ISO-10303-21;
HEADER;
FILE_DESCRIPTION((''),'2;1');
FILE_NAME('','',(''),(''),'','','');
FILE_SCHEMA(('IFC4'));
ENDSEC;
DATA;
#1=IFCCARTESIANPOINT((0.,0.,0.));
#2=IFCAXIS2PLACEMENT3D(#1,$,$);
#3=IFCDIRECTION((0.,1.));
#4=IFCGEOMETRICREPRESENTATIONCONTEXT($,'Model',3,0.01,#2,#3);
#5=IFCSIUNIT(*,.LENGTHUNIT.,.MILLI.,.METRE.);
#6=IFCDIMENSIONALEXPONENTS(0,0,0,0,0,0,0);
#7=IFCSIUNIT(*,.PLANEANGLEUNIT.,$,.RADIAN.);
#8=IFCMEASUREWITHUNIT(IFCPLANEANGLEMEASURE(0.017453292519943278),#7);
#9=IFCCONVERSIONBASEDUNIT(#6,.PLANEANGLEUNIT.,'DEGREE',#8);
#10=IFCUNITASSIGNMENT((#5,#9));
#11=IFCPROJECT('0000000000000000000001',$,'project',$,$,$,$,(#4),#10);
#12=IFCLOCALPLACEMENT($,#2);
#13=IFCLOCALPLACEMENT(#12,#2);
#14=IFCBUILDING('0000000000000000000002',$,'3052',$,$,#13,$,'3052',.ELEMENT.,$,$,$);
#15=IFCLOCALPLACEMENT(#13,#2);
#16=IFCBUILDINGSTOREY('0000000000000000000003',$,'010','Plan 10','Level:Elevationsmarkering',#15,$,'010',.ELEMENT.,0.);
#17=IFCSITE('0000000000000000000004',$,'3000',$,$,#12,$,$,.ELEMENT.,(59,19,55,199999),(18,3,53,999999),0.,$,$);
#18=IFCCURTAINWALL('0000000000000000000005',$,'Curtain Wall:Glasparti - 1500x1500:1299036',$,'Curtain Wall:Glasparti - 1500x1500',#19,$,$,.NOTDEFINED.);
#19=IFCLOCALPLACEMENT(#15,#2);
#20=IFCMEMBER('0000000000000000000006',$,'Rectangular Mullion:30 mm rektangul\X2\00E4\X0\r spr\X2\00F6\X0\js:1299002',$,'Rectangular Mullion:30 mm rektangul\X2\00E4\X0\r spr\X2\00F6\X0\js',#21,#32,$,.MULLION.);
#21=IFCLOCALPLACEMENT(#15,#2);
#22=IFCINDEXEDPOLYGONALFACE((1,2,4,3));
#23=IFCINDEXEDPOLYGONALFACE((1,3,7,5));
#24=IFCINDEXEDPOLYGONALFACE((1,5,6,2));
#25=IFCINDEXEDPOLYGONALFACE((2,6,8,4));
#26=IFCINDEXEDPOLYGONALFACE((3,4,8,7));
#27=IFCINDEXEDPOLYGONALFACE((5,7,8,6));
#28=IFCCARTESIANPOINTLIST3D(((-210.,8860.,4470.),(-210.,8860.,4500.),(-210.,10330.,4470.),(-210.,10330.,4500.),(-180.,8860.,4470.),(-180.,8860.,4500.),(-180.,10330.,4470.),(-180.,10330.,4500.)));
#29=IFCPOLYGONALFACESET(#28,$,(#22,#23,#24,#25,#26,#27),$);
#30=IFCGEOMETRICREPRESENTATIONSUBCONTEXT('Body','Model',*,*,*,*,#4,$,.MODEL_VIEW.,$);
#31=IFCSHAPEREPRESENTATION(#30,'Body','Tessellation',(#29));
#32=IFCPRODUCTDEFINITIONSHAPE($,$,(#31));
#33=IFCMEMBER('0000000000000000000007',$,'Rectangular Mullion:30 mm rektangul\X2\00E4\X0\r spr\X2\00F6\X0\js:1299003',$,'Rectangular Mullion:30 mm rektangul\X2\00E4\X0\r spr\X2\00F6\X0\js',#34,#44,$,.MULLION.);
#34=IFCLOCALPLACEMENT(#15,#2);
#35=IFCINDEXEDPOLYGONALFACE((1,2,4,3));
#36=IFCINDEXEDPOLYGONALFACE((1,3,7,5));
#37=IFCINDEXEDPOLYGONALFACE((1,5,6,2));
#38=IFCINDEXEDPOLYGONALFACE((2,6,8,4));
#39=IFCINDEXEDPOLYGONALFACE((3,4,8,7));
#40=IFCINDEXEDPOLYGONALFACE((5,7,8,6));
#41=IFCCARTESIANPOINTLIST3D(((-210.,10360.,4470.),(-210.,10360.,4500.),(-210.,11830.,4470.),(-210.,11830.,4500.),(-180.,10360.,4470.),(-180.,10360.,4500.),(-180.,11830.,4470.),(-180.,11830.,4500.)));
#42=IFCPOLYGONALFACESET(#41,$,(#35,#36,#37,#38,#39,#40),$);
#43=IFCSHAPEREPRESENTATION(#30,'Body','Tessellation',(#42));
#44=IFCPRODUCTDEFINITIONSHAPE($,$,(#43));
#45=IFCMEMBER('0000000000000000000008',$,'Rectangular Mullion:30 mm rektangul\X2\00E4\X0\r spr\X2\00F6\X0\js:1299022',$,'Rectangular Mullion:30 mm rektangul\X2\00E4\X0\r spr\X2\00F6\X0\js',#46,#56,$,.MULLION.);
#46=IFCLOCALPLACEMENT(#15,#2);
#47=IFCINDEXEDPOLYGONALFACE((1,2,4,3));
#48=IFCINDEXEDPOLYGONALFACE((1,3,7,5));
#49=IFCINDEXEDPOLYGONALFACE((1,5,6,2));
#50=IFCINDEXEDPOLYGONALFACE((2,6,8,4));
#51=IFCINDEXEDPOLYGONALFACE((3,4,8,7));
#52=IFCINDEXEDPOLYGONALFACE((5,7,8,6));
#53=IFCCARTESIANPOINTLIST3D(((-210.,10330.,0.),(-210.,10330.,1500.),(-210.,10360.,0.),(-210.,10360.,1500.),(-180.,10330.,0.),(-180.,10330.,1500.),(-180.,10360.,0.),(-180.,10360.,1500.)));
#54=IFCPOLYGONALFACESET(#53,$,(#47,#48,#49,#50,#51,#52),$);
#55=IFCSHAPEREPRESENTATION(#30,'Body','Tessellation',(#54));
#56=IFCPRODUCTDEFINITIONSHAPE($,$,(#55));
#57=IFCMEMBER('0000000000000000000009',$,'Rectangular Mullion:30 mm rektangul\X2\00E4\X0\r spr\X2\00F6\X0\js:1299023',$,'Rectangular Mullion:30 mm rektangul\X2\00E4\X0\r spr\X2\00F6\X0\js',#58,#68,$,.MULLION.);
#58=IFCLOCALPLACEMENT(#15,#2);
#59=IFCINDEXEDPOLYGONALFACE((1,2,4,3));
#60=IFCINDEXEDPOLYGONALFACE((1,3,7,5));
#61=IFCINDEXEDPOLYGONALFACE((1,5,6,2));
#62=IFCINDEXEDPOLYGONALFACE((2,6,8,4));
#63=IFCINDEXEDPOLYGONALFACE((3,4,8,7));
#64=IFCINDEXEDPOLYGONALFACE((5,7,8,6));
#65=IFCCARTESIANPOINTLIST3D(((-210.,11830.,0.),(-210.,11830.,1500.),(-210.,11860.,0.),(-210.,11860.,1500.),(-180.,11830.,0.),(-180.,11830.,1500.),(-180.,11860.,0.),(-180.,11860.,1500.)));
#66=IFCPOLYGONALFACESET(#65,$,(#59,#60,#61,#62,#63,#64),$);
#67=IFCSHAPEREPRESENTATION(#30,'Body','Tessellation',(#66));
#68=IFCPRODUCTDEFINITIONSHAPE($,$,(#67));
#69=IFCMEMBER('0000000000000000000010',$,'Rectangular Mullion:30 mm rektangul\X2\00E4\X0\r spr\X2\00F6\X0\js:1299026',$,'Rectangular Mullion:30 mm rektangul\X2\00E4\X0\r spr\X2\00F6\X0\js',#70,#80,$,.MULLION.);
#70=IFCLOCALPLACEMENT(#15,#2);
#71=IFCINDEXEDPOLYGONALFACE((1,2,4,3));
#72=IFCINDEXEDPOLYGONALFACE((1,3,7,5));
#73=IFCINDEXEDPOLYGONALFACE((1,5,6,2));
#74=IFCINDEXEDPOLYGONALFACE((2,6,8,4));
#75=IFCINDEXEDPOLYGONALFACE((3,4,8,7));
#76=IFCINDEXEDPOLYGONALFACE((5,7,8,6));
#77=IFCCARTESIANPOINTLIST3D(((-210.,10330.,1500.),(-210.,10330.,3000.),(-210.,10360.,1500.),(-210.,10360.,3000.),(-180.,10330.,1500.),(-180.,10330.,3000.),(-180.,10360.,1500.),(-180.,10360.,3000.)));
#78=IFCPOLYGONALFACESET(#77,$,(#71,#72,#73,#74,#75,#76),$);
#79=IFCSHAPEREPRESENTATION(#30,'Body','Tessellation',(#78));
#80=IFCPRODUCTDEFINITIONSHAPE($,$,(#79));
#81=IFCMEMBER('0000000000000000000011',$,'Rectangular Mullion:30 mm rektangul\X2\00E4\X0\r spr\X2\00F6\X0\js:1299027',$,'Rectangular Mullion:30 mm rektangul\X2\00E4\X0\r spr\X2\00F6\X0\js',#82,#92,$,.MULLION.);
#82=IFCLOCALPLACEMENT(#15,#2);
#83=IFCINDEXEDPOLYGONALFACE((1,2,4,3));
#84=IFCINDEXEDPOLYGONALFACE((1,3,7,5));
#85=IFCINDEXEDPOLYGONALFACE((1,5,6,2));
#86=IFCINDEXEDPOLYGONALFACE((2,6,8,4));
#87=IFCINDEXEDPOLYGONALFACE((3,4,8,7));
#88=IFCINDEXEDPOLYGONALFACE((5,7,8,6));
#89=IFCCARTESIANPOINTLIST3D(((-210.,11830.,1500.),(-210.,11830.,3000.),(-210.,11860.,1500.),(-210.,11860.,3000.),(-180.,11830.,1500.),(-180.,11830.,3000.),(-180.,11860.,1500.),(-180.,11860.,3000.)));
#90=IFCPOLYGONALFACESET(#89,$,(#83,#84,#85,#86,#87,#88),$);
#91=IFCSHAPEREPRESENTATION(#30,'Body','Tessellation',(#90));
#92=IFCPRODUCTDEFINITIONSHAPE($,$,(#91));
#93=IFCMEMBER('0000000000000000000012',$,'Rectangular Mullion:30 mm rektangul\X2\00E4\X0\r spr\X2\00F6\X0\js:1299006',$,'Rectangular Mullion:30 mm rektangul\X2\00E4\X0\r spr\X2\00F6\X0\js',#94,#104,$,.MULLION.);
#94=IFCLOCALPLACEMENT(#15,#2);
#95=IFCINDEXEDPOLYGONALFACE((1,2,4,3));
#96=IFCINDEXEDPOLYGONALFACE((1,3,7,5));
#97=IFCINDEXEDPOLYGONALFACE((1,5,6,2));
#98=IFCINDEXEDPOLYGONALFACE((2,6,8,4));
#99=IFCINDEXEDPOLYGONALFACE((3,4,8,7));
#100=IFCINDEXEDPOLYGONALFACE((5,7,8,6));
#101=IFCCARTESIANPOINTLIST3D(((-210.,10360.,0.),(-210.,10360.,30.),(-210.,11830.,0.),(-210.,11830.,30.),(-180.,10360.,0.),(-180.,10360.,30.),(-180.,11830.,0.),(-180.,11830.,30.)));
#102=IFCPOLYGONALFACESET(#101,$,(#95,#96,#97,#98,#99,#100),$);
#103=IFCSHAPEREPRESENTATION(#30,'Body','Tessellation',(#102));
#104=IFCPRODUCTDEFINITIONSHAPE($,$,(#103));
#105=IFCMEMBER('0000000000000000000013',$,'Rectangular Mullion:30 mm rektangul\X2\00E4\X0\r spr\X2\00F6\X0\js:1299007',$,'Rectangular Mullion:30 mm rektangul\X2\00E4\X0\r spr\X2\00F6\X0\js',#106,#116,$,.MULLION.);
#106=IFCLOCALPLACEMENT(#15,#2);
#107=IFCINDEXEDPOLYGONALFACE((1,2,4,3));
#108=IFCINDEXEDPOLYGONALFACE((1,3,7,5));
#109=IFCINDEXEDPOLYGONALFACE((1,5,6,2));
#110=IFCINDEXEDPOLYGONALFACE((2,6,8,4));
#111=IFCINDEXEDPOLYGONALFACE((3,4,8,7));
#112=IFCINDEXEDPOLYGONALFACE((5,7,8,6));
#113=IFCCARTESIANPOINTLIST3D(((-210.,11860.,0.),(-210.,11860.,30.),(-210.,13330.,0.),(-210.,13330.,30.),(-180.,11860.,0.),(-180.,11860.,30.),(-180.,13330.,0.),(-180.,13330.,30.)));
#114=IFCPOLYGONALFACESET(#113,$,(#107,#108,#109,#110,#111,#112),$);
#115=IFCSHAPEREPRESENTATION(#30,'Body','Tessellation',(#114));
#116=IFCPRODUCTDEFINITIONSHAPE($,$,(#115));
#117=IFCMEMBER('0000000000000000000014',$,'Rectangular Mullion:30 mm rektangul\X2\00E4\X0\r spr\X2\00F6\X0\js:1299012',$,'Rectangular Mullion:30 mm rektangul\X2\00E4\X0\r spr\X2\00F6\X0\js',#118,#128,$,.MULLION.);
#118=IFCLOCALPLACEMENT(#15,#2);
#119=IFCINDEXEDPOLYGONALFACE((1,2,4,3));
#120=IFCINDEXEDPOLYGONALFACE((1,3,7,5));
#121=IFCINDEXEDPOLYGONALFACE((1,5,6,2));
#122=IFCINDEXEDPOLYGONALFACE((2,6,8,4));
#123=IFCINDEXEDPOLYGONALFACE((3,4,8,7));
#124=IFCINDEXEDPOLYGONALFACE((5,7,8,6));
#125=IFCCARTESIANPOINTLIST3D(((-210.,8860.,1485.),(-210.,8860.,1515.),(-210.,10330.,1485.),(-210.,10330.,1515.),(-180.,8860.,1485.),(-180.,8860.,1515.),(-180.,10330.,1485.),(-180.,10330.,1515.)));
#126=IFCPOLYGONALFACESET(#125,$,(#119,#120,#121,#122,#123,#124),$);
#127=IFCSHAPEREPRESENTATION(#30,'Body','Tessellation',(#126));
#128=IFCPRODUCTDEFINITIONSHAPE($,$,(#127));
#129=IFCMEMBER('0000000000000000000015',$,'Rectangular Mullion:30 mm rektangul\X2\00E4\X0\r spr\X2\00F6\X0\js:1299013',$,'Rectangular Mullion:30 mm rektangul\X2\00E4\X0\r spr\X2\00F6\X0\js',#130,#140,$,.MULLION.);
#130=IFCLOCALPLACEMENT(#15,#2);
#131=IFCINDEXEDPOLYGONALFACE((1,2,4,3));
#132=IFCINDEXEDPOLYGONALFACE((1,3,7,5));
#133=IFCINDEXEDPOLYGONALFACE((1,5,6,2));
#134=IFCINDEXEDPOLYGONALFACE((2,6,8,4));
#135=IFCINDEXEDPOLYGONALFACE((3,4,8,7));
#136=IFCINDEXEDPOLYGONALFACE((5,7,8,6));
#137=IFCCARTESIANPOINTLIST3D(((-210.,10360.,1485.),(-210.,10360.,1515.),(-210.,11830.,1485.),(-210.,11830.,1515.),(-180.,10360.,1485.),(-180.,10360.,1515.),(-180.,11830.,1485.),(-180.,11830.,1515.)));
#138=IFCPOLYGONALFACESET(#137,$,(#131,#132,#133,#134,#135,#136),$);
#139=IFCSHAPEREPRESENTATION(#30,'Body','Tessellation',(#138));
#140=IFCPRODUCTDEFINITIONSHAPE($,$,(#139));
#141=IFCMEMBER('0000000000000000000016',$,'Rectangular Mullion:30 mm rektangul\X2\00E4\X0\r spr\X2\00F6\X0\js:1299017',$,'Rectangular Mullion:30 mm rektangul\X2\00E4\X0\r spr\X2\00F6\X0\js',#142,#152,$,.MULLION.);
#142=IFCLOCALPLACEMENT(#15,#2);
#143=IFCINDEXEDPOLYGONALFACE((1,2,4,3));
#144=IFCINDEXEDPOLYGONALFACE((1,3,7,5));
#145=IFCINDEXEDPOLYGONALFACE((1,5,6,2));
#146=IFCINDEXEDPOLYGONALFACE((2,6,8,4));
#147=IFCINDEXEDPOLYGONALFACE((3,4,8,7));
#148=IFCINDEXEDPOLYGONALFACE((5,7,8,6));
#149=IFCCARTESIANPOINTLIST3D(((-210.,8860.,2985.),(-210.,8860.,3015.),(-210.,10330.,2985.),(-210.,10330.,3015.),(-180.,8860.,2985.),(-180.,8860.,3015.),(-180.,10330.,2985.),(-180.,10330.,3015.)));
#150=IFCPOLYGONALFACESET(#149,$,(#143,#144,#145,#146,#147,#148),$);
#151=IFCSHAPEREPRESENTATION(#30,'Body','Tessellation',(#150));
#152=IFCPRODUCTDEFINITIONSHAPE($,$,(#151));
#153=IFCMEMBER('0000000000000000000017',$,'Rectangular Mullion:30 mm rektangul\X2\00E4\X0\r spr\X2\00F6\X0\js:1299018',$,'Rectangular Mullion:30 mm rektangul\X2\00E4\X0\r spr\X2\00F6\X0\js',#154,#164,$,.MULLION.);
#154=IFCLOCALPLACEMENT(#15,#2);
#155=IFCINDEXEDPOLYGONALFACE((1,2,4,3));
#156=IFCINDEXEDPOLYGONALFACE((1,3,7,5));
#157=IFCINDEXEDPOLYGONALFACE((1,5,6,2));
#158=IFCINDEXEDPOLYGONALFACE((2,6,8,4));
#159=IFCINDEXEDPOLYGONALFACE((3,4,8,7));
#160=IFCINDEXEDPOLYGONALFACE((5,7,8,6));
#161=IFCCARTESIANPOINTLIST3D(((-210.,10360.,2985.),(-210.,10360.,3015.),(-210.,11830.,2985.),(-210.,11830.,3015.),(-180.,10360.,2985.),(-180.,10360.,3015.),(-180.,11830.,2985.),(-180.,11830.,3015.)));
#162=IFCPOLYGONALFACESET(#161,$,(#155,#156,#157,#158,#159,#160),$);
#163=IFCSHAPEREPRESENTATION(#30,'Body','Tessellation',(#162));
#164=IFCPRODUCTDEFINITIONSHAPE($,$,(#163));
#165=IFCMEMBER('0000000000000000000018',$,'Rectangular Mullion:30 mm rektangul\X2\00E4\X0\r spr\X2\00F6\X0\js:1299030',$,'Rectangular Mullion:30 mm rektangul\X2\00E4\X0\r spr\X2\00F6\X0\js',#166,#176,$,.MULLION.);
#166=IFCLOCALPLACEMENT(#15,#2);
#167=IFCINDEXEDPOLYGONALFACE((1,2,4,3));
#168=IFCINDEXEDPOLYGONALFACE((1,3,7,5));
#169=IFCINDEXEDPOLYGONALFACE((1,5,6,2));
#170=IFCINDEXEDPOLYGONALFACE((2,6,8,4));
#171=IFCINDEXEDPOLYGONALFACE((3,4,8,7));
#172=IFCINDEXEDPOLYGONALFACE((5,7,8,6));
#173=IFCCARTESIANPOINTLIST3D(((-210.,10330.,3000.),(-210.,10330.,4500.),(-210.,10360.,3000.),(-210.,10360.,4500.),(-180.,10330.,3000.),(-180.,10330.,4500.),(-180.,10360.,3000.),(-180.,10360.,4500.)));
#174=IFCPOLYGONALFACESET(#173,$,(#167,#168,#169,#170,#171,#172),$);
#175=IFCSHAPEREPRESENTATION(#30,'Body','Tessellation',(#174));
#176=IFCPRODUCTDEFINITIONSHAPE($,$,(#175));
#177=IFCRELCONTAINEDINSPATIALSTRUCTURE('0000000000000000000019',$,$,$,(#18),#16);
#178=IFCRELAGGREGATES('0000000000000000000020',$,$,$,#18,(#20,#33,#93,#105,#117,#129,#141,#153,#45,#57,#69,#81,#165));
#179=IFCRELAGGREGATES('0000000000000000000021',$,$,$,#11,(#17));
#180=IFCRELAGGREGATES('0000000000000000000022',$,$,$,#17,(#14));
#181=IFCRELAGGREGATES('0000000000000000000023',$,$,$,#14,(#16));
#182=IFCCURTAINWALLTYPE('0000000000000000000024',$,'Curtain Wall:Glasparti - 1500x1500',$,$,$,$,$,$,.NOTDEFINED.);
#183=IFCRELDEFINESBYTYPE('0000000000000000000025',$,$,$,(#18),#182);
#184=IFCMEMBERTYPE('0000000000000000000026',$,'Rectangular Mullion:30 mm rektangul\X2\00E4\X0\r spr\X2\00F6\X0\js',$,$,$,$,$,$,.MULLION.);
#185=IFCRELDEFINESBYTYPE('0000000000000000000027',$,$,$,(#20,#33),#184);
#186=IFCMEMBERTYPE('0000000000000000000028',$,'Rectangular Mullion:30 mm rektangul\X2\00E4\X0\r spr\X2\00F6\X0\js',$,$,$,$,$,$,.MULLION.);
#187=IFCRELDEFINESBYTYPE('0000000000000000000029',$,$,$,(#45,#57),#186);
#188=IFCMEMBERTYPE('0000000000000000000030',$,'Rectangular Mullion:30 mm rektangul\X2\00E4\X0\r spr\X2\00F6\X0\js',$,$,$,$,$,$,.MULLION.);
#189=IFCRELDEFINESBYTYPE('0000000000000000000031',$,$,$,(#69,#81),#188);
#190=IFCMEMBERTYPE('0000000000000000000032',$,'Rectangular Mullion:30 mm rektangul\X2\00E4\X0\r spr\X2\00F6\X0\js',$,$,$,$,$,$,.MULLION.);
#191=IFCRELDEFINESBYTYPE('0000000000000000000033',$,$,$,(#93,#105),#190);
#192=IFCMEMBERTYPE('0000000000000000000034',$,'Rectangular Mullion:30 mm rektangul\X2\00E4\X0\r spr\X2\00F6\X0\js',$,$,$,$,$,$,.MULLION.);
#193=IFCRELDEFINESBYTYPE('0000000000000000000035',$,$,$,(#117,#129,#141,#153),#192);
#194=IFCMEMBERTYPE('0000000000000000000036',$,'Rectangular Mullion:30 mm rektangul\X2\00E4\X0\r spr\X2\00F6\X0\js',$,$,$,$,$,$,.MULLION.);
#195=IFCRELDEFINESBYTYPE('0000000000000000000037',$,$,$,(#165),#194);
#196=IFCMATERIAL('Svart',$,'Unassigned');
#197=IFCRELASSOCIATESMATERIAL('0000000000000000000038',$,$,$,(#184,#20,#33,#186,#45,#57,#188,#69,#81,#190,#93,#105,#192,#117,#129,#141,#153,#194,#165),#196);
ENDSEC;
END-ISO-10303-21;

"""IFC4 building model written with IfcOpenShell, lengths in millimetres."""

from ifc_helpers import new_model, entity, si_unit, converted_unit, direction, frame, origin, place, context, subcontext, project, spatial, indexed_curve, outline, extrude, source, transform, mapped, material, type_object, type_shapes, element, aggregate, save


model = new_model("IFC4")

# Units and contexts
model_context = context("Model", 3, precision=0.01, world=origin(), true_north=direction((0.0, 1.0)))
body_context = subcontext(model_context, "Body", "Model", "MODEL_VIEW")
ifc_project = project(units=[si_unit("LENGTHUNIT", "METRE", prefix="MILLI"), converted_unit("PLANEANGLEUNIT", "DEGREE", entity("IfcPlaneAngleMeasure", 0.017453292519943278), si_unit("PLANEANGLEUNIT", "RADIAN"), dimensions=[0, 0, 0, 0, 0, 0, 0])], contexts=[model_context])

# Site, building, storey
site_placement = place(None, origin())
site = spatial("IfcSite", under=ifc_project, at=site_placement, Name="3000", CompositionType="ELEMENT", RefLatitude=(59, 19, 55, 199999), RefLongitude=(18, 3, 53, 999999), RefElevation=0.0)
building_placement = place(site_placement, origin())
building = spatial("IfcBuilding", under=site, at=building_placement, Name="3052", LongName="3052", CompositionType="ELEMENT")
storey_placement = place(building_placement, origin())
storey = spatial("IfcBuildingStorey", under=building, at=storey_placement, Name="010", Description="Plan 10", ObjectType="Level:Elevationsmarkering", LongName="010", CompositionType="ELEMENT", Elevation=0.0)

# Curtain wall, members
curtain_wall_type = type_object("IfcCurtainWallType", Name="Curtain Wall:Glasparti - 1500x1500", PredefinedType="NOTDEFINED")
curtain_wall_placement = place(storey_placement, origin())
curtain_wall = element("IfcCurtainWall", 1, at=curtain_wall_placement, inside=storey, type_object=curtain_wall_type, Name="Curtain Wall:Glasparti - 1500x1500:1299036", ObjectType="Curtain Wall:Glasparti - 1500x1500", PredefinedType="NOTDEFINED")
ifc_material_1 = material(Name="Svart", Category="Unassigned")
member_type_1 = type_object("IfcMemberType", Name="Rectangular Mullion:30 mm rektangulär spröjs", PredefinedType="MULLION", material=ifc_material_1)
shared_shape_1 = source(origin(), body_context, "Body", "SweptSolid", [
    extrude(outline(indexed_curve([(-15.0, -15.0), (15.0, -15.0), (15.0, 15.0), (-15.0, 15.0), (-15.0, -15.0)], self_intersect=False)), frame((-15.0, 0.0, -1470.0), z_axis=(0.0, 0.0, 1.0), x_axis=(-1.0, 0.0, 0.0)), (0.0, 0.0, 1.0), 1470.0),
])
type_shapes(member_type_1, [shared_shape_1])
member_1_placement = place(curtain_wall_placement, frame((-195.0, 10330.0, 4500.0), z_axis=(0.0, 1.0, 0.0), x_axis=(0.0, 0.0, 1.0)))
member_1 = element("IfcMember", 2, at=member_1_placement, type_object=member_type_1, material=ifc_material_1, Name="Rectangular Mullion:30 mm rektangulär spröjs:1299002", ObjectType="Rectangular Mullion:30 mm rektangulär spröjs", PredefinedType="MULLION", context=body_context, shape_type="MappedRepresentation", body=[
    mapped(shared_shape_1, transform((0.0, 0.0, 0.0), scale=1.0)),
])
member_2_placement = place(curtain_wall_placement, frame((-195.0, 11830.0, 4500.0), z_axis=(0.0, 1.0, 0.0), x_axis=(0.0, 0.0, 1.0)))
member_2 = element("IfcMember", 3, at=member_2_placement, type_object=member_type_1, material=ifc_material_1, Name="Rectangular Mullion:30 mm rektangulär spröjs:1299003", ObjectType="Rectangular Mullion:30 mm rektangulär spröjs", PredefinedType="MULLION", context=body_context, shape_type="MappedRepresentation", body=[
    mapped(shared_shape_1, transform((0.0, 0.0, 0.0), scale=1.0)),
])
member_type_2 = type_object("IfcMemberType", Name="Rectangular Mullion:30 mm rektangulär spröjs", PredefinedType="MULLION", material=ifc_material_1)
shared_shape_2 = source(origin(), body_context, "Body", "SweptSolid", [
    extrude(outline(indexed_curve([(-15.0, -15.0), (15.0, -15.0), (15.0, 15.0), (-15.0, 15.0), (-15.0, -15.0)], self_intersect=False)), frame((0.0, 0.0, -1500.0), z_axis=(0.0, 0.0, 1.0), x_axis=(-1.0, 0.0, 0.0)), (0.0, 0.0, 1.0), 1500.0),
])
type_shapes(member_type_2, [shared_shape_2])
member_3_placement = place(curtain_wall_placement, frame((-195.0, 10345.0, 0.0), z_axis=(0.0, 0.0, -1.0), x_axis=(0.0, 1.0, 0.0)))
member_3 = element("IfcMember", 4, at=member_3_placement, type_object=member_type_2, material=ifc_material_1, Name="Rectangular Mullion:30 mm rektangulär spröjs:1299022", ObjectType="Rectangular Mullion:30 mm rektangulär spröjs", PredefinedType="MULLION", context=body_context, shape_type="MappedRepresentation", body=[
    mapped(shared_shape_2, transform((0.0, 0.0, 0.0), scale=1.0)),
])
member_4_placement = place(curtain_wall_placement, frame((-195.0, 11845.0, 0.0), z_axis=(0.0, 0.0, -1.0), x_axis=(0.0, 1.0, 0.0)))
member_4 = element("IfcMember", 5, at=member_4_placement, type_object=member_type_2, material=ifc_material_1, Name="Rectangular Mullion:30 mm rektangulär spröjs:1299023", ObjectType="Rectangular Mullion:30 mm rektangulär spröjs", PredefinedType="MULLION", context=body_context, shape_type="MappedRepresentation", body=[
    mapped(shared_shape_2, transform((0.0, 0.0, 0.0), scale=1.0)),
])
member_type_3 = type_object("IfcMemberType", Name="Rectangular Mullion:30 mm rektangulär spröjs", PredefinedType="MULLION", material=ifc_material_1)
shared_shape_3 = source(origin(), body_context, "Body", "SweptSolid", [
    extrude(outline(indexed_curve([(-15.0, -15.0), (15.0, -15.0), (15.0, 15.0), (-15.0, 15.0), (-15.0, -15.0)], self_intersect=False)), frame((0.0, 0.0, -1500.0), z_axis=(0.0, 0.0, 1.0), x_axis=(-1.0, 0.0, 0.0)), (0.0, 0.0, 1.0), 1500.0),
])
type_shapes(member_type_3, [shared_shape_3])
member_5_placement = place(curtain_wall_placement, frame((-195.0, 10345.0, 1500.0), z_axis=(0.0, 0.0, -1.0), x_axis=(0.0, 1.0, 0.0)))
member_5 = element("IfcMember", 6, at=member_5_placement, type_object=member_type_3, material=ifc_material_1, Name="Rectangular Mullion:30 mm rektangulär spröjs:1299026", ObjectType="Rectangular Mullion:30 mm rektangulär spröjs", PredefinedType="MULLION", context=body_context, shape_type="MappedRepresentation", body=[
    mapped(shared_shape_3, transform((0.0, 0.0, 0.0), scale=1.0)),
])
member_6_placement = place(curtain_wall_placement, frame((-195.0, 11845.0, 1500.0), z_axis=(0.0, 0.0, -1.0), x_axis=(0.0, 1.0, 0.0)))
member_6 = element("IfcMember", 7, at=member_6_placement, type_object=member_type_3, material=ifc_material_1, Name="Rectangular Mullion:30 mm rektangulär spröjs:1299027", ObjectType="Rectangular Mullion:30 mm rektangulär spröjs", PredefinedType="MULLION", context=body_context, shape_type="MappedRepresentation", body=[
    mapped(shared_shape_3, transform((0.0, 0.0, 0.0), scale=1.0)),
])
member_type_4 = type_object("IfcMemberType", Name="Rectangular Mullion:30 mm rektangulär spröjs", PredefinedType="MULLION", material=ifc_material_1)
shared_shape_4 = source(origin(), body_context, "Body", "SweptSolid", [
    extrude(outline(indexed_curve([(-15.0, -15.0), (15.0, -15.0), (15.0, 15.0), (-15.0, 15.0), (-15.0, -15.0)], self_intersect=False)), frame((-15.0, 0.0, -1470.0), z_axis=(0.0, 0.0, 1.0), x_axis=(-1.0, 0.0, 0.0)), (0.0, 0.0, 1.0), 1470.0),
])
type_shapes(member_type_4, [shared_shape_4])
member_7_placement = place(curtain_wall_placement, frame((-195.0, 10360.0, 0.0), z_axis=(0.0, -1.0, 0.0), x_axis=(0.0, 0.0, -1.0)))
member_7 = element("IfcMember", 8, at=member_7_placement, type_object=member_type_4, material=ifc_material_1, Name="Rectangular Mullion:30 mm rektangulär spröjs:1299006", ObjectType="Rectangular Mullion:30 mm rektangulär spröjs", PredefinedType="MULLION", context=body_context, shape_type="MappedRepresentation", body=[
    mapped(shared_shape_4, transform((0.0, 0.0, 0.0), scale=1.0)),
])
member_8_placement = place(curtain_wall_placement, frame((-195.0, 11860.0, 0.0), z_axis=(0.0, -1.0, 0.0), x_axis=(0.0, 0.0, -1.0)))
member_8 = element("IfcMember", 9, at=member_8_placement, type_object=member_type_4, material=ifc_material_1, Name="Rectangular Mullion:30 mm rektangulär spröjs:1299007", ObjectType="Rectangular Mullion:30 mm rektangulär spröjs", PredefinedType="MULLION", context=body_context, shape_type="MappedRepresentation", body=[
    mapped(shared_shape_4, transform((0.0, 0.0, 0.0), scale=1.0)),
])
member_type_5 = type_object("IfcMemberType", Name="Rectangular Mullion:30 mm rektangulär spröjs", PredefinedType="MULLION", material=ifc_material_1)
shared_shape_5 = source(origin(), body_context, "Body", "SweptSolid", [
    extrude(outline(indexed_curve([(-15.0, -15.0), (15.0, -15.0), (15.0, 15.0), (-15.0, 15.0), (-15.0, -15.0)], self_intersect=False)), frame((0.0, 0.0, -1470.0), z_axis=(0.0, 0.0, 1.0), x_axis=(-1.0, 0.0, 0.0)), (0.0, 0.0, 1.0), 1470.0),
])
type_shapes(member_type_5, [shared_shape_5])
member_9_placement = place(curtain_wall_placement, frame((-195.0, 10330.0, 1500.0), z_axis=(0.0, 1.0, 0.0), x_axis=(0.0, 0.0, 1.0)))
member_9 = element("IfcMember", 10, at=member_9_placement, type_object=member_type_5, material=ifc_material_1, Name="Rectangular Mullion:30 mm rektangulär spröjs:1299012", ObjectType="Rectangular Mullion:30 mm rektangulär spröjs", PredefinedType="MULLION", context=body_context, shape_type="MappedRepresentation", body=[
    mapped(shared_shape_5, transform((0.0, 0.0, 0.0), scale=1.0)),
])
member_10_placement = place(curtain_wall_placement, frame((-195.0, 11830.0, 1500.0), z_axis=(0.0, 1.0, 0.0), x_axis=(0.0, 0.0, 1.0)))
member_10 = element("IfcMember", 11, at=member_10_placement, type_object=member_type_5, material=ifc_material_1, Name="Rectangular Mullion:30 mm rektangulär spröjs:1299013", ObjectType="Rectangular Mullion:30 mm rektangulär spröjs", PredefinedType="MULLION", context=body_context, shape_type="MappedRepresentation", body=[
    mapped(shared_shape_5, transform((0.0, 0.0, 0.0), scale=1.0)),
])
member_11_placement = place(curtain_wall_placement, frame((-195.0, 10330.0, 3000.0), z_axis=(0.0, 1.0, 0.0), x_axis=(0.0, 0.0, 1.0)))
member_11 = element("IfcMember", 12, at=member_11_placement, type_object=member_type_5, material=ifc_material_1, Name="Rectangular Mullion:30 mm rektangulär spröjs:1299017", ObjectType="Rectangular Mullion:30 mm rektangulär spröjs", PredefinedType="MULLION", context=body_context, shape_type="MappedRepresentation", body=[
    mapped(shared_shape_5, transform((0.0, 0.0, 0.0), scale=1.0)),
])
member_12_placement = place(curtain_wall_placement, frame((-195.0, 11830.0, 3000.0), z_axis=(0.0, 1.0, 0.0), x_axis=(0.0, 0.0, 1.0)))
member_12 = element("IfcMember", 13, at=member_12_placement, type_object=member_type_5, material=ifc_material_1, Name="Rectangular Mullion:30 mm rektangulär spröjs:1299018", ObjectType="Rectangular Mullion:30 mm rektangulär spröjs", PredefinedType="MULLION", context=body_context, shape_type="MappedRepresentation", body=[
    mapped(shared_shape_5, transform((0.0, 0.0, 0.0), scale=1.0)),
])
member_type_6 = type_object("IfcMemberType", Name="Rectangular Mullion:30 mm rektangulär spröjs", PredefinedType="MULLION", material=ifc_material_1)
shared_shape_6 = source(origin(), body_context, "Body", "SweptSolid", [
    extrude(outline(indexed_curve([(-15.0, -15.0), (15.0, -15.0), (15.0, 15.0), (-15.0, 15.0), (-15.0, -15.0)], self_intersect=False)), frame((0.0, 0.0, -1500.0), z_axis=(0.0, 0.0, 1.0), x_axis=(-1.0, 0.0, 0.0)), (0.0, 0.0, 1.0), 1500.0),
])
type_shapes(member_type_6, [shared_shape_6])
member_13_placement = place(curtain_wall_placement, frame((-195.0, 10345.0, 3000.0), z_axis=(0.0, 0.0, -1.0), x_axis=(0.0, 1.0, 0.0)))
member_13 = element("IfcMember", 14, at=member_13_placement, type_object=member_type_6, material=ifc_material_1, Name="Rectangular Mullion:30 mm rektangulär spröjs:1299030", ObjectType="Rectangular Mullion:30 mm rektangulär spröjs", PredefinedType="MULLION", context=body_context, shape_type="MappedRepresentation", body=[
    mapped(shared_shape_6, transform((0.0, 0.0, 0.0), scale=1.0)),
])
aggregate(curtain_wall, [member_1, member_2, member_7, member_8, member_9, member_10, member_11, member_12, member_3, member_4, member_5, member_6, member_13])

save(model, "model.ifc")
